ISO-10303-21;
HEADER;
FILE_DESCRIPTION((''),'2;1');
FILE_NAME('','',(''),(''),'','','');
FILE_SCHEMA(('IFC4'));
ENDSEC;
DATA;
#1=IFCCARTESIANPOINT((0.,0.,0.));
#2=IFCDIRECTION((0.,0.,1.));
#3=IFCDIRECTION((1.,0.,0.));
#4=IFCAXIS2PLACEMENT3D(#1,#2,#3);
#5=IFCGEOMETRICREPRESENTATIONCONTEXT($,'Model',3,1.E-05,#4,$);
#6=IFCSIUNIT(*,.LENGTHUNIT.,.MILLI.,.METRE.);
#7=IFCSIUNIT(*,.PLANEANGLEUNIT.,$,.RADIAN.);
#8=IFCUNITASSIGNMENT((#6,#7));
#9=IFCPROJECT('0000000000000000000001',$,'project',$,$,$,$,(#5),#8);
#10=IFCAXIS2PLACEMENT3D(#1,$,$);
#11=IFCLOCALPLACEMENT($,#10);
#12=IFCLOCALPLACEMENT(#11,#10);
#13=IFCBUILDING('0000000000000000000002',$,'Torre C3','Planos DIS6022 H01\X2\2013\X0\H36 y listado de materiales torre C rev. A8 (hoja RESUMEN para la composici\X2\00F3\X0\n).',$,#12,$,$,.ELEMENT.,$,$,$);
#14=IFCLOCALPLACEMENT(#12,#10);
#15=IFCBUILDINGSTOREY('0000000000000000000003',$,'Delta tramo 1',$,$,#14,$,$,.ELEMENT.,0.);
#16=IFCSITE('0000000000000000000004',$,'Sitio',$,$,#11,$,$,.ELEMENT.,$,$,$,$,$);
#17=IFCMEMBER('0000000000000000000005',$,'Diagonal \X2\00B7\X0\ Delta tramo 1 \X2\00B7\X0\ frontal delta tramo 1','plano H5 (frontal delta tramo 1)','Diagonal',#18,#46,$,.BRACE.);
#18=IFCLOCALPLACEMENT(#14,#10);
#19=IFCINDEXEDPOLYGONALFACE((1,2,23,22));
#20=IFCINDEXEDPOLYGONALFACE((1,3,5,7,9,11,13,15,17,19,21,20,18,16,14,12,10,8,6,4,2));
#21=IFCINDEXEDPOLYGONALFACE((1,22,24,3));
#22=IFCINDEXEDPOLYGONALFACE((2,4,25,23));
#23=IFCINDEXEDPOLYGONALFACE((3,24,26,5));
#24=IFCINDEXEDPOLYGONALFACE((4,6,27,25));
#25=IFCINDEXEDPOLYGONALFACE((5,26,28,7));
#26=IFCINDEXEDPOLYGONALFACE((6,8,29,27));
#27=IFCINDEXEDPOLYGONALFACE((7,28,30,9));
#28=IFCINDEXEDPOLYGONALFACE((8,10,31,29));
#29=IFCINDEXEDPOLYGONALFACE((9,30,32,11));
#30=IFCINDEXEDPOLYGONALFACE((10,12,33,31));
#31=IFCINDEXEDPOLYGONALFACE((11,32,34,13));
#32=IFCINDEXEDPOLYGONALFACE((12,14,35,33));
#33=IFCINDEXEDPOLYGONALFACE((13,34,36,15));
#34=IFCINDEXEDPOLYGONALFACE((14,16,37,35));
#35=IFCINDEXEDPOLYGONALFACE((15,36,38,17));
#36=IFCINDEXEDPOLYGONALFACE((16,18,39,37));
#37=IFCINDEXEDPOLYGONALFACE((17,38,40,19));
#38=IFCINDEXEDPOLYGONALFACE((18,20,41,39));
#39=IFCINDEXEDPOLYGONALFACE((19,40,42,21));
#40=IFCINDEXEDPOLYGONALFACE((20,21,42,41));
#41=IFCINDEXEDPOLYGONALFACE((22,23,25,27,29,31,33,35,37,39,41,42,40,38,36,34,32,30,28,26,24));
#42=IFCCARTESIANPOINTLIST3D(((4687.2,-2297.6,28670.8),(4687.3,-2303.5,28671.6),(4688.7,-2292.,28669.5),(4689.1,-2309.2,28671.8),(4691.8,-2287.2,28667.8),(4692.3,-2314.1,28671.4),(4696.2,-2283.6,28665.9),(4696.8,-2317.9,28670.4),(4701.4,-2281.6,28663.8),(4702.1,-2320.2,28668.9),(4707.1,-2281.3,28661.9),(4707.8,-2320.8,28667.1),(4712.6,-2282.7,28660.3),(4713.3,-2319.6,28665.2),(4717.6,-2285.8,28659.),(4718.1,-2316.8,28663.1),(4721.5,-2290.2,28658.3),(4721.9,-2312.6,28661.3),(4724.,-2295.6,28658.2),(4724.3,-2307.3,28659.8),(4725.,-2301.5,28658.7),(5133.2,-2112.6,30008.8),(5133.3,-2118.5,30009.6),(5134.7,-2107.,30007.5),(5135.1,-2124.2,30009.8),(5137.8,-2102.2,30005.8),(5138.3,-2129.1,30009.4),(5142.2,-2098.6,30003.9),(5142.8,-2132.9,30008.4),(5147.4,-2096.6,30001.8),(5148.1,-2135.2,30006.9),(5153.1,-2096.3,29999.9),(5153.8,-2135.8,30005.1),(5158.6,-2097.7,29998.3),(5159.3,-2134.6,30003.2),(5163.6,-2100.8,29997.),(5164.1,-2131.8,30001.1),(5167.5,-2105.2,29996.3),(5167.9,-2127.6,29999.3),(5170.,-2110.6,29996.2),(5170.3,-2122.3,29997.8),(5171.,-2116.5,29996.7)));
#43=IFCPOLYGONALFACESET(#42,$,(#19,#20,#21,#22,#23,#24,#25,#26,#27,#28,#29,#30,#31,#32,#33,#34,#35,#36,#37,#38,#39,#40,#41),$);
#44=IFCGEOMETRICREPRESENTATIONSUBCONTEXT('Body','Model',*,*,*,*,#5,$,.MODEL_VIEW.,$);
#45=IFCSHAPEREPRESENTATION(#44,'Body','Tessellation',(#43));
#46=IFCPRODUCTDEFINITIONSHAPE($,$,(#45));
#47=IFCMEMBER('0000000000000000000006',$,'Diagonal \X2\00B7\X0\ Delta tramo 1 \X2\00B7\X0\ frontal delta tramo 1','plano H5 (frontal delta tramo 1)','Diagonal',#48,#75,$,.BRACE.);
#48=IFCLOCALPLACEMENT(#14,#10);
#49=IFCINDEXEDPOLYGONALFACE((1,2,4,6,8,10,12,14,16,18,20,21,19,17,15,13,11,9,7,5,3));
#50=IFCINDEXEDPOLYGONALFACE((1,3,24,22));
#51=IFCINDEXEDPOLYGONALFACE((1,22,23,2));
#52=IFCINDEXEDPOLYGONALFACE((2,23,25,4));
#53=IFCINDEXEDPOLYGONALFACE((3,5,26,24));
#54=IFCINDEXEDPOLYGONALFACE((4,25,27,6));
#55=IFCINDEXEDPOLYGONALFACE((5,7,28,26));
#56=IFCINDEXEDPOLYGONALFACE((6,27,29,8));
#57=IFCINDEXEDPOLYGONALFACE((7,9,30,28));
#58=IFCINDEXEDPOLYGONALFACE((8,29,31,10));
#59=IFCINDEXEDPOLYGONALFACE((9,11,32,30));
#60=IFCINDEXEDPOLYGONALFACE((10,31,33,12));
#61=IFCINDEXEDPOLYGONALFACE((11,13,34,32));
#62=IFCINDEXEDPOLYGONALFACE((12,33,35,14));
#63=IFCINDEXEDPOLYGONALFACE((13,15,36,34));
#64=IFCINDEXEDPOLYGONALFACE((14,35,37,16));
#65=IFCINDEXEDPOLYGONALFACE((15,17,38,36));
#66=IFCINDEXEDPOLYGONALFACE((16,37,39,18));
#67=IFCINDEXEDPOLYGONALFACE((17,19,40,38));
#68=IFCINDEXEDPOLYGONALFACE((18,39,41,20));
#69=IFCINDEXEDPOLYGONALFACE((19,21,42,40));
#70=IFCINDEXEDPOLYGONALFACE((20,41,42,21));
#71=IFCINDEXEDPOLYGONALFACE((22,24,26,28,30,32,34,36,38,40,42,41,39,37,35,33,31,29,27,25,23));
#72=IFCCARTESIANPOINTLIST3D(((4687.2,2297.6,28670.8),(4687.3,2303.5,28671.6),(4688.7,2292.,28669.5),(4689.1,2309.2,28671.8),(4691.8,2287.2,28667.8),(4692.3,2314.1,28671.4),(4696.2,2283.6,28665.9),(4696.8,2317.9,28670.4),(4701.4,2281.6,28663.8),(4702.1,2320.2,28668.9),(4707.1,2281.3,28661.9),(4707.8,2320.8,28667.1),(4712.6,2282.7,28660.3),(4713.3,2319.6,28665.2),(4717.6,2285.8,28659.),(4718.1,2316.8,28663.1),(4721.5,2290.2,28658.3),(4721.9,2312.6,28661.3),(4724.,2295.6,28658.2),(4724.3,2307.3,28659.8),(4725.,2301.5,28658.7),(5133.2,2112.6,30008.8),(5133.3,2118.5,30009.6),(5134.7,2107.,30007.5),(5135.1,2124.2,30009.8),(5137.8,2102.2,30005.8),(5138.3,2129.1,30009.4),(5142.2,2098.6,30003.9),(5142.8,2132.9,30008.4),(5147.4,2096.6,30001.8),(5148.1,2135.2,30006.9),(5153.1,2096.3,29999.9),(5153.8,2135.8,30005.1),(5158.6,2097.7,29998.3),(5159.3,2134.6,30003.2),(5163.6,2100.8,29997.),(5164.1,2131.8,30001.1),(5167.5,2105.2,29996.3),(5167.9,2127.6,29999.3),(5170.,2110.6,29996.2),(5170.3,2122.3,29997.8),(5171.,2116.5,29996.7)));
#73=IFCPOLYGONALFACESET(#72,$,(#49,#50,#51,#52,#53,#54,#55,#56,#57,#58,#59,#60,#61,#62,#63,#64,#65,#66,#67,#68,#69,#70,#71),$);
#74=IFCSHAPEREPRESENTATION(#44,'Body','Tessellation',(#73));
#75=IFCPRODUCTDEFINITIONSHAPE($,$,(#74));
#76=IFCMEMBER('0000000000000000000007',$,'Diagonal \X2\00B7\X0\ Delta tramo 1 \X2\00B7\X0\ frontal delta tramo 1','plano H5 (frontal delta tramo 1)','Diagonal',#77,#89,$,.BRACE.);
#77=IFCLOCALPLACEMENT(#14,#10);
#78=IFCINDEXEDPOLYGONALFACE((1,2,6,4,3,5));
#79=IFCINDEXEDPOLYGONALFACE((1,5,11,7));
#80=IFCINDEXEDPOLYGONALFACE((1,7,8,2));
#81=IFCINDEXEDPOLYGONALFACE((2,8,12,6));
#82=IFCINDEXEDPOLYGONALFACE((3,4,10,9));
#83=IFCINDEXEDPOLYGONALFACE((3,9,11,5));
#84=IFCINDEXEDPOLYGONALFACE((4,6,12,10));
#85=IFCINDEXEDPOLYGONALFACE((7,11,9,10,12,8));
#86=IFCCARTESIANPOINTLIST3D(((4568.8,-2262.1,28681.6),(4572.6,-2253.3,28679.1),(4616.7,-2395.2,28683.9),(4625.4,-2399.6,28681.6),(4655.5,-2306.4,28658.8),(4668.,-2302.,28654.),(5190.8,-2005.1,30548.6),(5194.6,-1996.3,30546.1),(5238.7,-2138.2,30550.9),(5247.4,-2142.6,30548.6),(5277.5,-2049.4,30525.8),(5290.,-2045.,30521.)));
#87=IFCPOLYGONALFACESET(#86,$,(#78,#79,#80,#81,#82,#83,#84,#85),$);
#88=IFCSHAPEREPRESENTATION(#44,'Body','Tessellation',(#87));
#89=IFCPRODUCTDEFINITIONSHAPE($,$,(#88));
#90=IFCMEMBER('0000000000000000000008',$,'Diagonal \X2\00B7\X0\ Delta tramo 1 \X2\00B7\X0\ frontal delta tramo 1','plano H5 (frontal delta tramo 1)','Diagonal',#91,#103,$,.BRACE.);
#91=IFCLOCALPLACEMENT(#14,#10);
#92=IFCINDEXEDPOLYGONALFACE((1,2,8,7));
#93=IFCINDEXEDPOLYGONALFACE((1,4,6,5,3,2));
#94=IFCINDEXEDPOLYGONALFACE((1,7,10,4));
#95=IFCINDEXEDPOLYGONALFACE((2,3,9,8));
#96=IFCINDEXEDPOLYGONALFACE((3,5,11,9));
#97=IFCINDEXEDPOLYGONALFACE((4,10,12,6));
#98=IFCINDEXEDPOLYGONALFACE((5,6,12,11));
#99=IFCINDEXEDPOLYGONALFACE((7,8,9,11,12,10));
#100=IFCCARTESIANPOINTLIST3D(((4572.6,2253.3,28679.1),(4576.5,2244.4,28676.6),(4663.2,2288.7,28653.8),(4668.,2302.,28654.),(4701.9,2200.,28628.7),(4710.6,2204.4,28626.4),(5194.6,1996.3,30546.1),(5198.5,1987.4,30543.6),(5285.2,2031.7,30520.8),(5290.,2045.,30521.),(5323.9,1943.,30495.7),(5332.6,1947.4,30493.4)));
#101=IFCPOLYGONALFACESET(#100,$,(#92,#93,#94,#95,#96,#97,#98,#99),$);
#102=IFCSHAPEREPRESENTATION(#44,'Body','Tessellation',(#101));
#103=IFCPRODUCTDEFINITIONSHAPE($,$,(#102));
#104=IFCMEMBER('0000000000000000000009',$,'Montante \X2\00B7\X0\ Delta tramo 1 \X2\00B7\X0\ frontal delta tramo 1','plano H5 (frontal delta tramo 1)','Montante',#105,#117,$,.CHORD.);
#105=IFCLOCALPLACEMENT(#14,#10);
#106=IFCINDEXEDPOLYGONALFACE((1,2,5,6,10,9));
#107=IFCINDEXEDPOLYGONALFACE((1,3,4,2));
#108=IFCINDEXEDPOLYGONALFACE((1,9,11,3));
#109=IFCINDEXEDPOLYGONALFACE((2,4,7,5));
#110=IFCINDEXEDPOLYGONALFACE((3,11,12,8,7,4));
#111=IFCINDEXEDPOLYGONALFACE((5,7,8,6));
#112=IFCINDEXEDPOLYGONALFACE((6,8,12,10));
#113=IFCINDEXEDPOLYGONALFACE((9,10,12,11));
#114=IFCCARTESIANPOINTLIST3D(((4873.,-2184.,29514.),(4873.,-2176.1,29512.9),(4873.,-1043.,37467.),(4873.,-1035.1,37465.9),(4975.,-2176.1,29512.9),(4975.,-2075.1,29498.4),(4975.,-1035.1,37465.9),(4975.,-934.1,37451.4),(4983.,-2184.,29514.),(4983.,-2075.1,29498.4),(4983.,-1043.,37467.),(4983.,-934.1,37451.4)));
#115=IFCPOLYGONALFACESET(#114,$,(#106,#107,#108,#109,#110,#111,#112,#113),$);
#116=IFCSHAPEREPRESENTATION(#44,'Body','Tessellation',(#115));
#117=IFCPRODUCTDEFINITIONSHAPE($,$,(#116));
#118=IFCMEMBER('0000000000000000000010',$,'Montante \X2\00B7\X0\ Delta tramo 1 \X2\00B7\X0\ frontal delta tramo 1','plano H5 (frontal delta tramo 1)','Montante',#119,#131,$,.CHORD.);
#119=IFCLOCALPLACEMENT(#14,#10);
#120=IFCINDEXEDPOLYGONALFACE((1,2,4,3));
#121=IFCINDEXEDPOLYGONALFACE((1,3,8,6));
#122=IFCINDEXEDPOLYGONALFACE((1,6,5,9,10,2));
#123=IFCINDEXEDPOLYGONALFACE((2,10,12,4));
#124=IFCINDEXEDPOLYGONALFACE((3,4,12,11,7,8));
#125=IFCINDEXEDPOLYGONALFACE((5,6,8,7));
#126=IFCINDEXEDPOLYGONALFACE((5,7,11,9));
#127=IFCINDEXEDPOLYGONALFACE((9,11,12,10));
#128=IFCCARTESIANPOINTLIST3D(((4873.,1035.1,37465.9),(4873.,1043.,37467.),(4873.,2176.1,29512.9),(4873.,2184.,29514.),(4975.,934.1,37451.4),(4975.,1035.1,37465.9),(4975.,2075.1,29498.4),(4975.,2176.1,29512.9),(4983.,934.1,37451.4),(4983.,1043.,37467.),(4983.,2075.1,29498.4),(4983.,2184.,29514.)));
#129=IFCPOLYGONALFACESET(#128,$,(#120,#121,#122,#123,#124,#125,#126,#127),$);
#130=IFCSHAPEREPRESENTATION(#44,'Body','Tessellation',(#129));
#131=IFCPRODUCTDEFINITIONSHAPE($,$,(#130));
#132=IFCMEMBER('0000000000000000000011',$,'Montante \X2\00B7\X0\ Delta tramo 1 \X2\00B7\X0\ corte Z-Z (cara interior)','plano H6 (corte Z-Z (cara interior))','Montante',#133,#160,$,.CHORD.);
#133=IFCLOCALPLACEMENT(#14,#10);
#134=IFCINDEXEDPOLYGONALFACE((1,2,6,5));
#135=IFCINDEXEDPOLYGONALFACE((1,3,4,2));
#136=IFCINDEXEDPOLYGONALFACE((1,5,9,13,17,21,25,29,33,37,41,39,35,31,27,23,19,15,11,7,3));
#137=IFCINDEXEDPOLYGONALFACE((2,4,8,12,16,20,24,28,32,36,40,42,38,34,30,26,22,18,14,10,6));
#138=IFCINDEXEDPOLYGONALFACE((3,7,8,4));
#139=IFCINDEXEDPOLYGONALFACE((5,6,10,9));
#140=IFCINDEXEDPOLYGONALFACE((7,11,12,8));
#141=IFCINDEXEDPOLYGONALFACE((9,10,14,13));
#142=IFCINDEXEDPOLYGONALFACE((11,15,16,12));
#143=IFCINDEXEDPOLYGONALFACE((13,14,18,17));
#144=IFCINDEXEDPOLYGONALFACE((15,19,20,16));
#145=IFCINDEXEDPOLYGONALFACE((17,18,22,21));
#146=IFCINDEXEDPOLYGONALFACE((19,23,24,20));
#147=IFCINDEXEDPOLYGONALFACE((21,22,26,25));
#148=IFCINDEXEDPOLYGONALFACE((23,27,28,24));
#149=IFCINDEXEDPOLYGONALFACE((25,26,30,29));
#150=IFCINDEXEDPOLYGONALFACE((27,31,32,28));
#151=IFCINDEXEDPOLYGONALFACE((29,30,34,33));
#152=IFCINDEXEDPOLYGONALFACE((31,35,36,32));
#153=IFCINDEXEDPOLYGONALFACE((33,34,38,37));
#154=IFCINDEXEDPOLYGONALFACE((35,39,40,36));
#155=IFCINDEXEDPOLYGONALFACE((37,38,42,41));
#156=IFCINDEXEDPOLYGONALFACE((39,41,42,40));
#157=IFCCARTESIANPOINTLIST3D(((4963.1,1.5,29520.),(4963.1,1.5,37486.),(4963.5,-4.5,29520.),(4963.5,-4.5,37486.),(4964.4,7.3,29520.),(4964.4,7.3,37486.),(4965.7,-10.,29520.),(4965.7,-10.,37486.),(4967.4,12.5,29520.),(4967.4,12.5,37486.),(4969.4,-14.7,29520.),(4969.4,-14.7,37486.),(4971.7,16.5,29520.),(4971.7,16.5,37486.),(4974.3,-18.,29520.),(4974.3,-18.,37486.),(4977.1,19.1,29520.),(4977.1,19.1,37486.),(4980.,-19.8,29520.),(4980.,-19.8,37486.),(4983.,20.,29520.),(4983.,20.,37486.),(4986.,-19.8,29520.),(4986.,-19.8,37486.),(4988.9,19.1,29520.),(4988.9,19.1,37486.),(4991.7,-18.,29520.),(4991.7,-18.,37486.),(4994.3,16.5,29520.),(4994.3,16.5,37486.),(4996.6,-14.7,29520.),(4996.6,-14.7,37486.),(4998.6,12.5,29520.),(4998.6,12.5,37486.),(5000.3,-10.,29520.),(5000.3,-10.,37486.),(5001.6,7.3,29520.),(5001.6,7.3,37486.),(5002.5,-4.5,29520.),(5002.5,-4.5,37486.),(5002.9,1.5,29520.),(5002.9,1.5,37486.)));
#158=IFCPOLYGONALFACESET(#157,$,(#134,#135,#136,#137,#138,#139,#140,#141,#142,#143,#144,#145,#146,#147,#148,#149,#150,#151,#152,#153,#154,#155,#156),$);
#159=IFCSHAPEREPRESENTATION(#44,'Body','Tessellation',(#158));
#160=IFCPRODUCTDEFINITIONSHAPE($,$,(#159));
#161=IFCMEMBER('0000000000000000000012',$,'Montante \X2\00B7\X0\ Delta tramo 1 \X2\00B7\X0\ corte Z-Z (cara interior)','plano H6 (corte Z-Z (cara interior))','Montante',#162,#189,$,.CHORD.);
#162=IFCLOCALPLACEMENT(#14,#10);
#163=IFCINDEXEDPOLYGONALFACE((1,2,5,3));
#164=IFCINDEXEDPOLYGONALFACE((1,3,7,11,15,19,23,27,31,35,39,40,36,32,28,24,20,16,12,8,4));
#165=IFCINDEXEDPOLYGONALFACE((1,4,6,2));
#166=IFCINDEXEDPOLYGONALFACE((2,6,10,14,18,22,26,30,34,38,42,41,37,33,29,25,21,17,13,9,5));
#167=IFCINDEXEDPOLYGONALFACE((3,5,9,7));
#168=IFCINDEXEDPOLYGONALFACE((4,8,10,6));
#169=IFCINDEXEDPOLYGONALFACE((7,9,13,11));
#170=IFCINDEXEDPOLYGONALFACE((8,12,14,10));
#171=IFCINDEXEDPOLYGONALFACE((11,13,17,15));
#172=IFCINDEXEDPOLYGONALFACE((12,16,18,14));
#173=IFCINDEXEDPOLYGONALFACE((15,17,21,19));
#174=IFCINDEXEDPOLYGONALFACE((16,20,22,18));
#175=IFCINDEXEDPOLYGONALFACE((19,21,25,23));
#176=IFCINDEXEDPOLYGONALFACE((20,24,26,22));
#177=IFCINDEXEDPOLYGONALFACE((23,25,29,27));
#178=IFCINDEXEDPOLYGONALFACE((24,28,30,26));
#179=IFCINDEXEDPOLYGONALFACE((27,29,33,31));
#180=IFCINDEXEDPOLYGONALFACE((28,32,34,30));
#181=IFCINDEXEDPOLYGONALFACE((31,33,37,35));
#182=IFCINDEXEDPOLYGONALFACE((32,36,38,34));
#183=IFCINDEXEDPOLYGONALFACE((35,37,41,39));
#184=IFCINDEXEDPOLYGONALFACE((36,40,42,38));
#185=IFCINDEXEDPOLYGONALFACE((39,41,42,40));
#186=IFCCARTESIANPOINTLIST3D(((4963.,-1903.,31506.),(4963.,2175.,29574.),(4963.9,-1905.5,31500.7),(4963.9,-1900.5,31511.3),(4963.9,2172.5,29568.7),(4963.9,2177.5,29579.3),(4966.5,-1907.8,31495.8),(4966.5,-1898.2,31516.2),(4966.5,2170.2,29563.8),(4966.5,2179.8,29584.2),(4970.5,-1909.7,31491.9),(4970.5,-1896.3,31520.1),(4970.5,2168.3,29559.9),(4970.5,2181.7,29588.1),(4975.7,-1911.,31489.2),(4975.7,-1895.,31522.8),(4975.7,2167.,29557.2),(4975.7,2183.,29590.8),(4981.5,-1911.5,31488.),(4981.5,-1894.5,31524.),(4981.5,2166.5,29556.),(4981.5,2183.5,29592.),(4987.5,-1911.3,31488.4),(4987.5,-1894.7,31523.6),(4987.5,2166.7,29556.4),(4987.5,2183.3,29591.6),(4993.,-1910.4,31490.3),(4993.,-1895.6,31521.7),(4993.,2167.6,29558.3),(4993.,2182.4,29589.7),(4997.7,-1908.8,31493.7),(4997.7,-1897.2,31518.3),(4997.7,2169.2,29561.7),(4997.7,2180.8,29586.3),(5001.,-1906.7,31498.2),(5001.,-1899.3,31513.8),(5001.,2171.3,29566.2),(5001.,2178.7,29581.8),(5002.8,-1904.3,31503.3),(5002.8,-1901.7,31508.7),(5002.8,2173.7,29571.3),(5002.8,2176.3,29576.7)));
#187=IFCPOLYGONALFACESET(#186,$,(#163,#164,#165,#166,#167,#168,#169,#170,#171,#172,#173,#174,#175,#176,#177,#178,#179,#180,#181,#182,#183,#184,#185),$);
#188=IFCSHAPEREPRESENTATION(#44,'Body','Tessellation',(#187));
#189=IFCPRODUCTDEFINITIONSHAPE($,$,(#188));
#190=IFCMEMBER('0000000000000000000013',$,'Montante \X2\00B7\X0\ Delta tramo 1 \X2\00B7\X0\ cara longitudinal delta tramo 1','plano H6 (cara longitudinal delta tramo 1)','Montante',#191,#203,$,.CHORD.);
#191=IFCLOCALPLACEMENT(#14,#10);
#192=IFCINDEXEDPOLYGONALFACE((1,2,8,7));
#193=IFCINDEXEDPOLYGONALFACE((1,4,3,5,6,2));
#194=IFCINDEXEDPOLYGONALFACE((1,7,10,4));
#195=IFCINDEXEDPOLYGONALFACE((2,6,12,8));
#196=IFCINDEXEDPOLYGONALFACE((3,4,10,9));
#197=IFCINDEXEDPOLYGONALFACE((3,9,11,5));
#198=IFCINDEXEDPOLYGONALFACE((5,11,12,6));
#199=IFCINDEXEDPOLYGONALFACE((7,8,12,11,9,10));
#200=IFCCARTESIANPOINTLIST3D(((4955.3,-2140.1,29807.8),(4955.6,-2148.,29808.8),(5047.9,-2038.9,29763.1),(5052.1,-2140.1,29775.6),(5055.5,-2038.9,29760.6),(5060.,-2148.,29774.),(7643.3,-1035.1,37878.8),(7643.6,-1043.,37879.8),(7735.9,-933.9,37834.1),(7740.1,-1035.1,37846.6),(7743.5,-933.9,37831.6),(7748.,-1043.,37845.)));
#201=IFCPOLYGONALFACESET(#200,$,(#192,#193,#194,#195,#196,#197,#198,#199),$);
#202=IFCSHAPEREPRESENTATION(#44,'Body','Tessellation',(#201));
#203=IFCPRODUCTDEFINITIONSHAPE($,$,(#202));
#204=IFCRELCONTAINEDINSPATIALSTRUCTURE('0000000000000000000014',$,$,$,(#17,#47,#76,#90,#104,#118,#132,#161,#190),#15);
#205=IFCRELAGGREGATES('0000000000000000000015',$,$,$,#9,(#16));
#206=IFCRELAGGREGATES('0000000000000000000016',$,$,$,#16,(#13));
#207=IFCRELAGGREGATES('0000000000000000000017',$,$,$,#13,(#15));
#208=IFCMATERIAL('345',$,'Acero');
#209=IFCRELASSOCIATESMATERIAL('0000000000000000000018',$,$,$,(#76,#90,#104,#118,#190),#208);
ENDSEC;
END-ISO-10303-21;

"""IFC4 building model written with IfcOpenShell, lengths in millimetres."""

from ifc_helpers import new_model, si_unit, frame, frame_2d, origin, origin_with_axes, place, context, subcontext, project, spatial, circle, l_section, extrude, material, element, save


model = new_model("IFC4")

# Units and contexts
model_context = context("Model", 3, precision=1e-05, world=origin_with_axes())
body_context = subcontext(model_context, "Body", "Model", "MODEL_VIEW")
ifc_project = project(units=[si_unit("LENGTHUNIT", "METRE", prefix="MILLI"), si_unit("PLANEANGLEUNIT", "RADIAN")], contexts=[model_context])

# Site, building, storey
site_placement = place(None, origin())
site = spatial("IfcSite", under=ifc_project, at=site_placement, Name="Sitio", CompositionType="ELEMENT")
building_placement = place(site_placement, origin())
building = spatial("IfcBuilding", under=site, at=building_placement, Name="Torre C3", Description="Planos DIS6022 H01–H36 y listado de materiales torre C rev. A8 (hoja RESUMEN para la composición).", CompositionType="ELEMENT")
storey_placement = place(building_placement, origin())
storey = spatial("IfcBuildingStorey", under=building, at=storey_placement, Name="Delta tramo 1", CompositionType="ELEMENT", Elevation=0.0)

# Members
for number, where, z_axis, x_axis, name in (
    (1, (4706.0, -2301.0, 28665.0), (0.313542, 0.130057, 0.940626), (-0.863292, 0.451616, 0.225321), "Diagonal · Delta tramo 1 · frontal delta tramo 1"),
    (2, (4706.0, 2301.0, 28665.0), (0.313542, -0.130057, 0.940626), (-0.863292, -0.451616, 0.225321), "Diagonal · Delta tramo 1 · frontal delta tramo 1"),
):
    element("IfcMember", number, at=place(storey_placement, frame(where, z_axis=z_axis, x_axis=x_axis)), inside=storey, Name=name, Description="plano H5 (frontal delta tramo 1)", ObjectType="Diagonal", PredefinedType="BRACE", context=body_context, shape_type="SweptSolid", body=[
        extrude(circle(Radius=20.0), None, (0.0, 0.0, 1.0), 1422.5),
    ])
ifc_material_1 = material(Name="345", Category="Acero")
for number, where, z_axis, x_axis, name in (
    (3, (4668.0, -2302.0, 28654.0), (0.313414, 0.129497, 0.940746), (-0.867067, 0.443015, 0.227885), "Diagonal · Delta tramo 1 · frontal delta tramo 1"),
    (4, (4668.0, 2302.0, 28654.0), (0.313414, -0.129497, 0.940746), (-0.867067, -0.443015, 0.227885), "Diagonal · Delta tramo 1 · frontal delta tramo 1"),
):
    element("IfcMember", number, at=place(storey_placement, frame(where, z_axis=z_axis, x_axis=x_axis)), inside=storey, material=ifc_material_1, Name=name, Description="plano H5 (frontal delta tramo 1)", ObjectType="Diagonal", PredefinedType="BRACE", context=body_context, shape_type="SweptSolid", body=[
        extrude(l_section(Depth=110.0, Width=110.0, Thickness=10.0, at=frame_2d((55.0, 55.0))), None, (0.0, 0.0, 1.0), 1984.6),
    ])
for number, where, z_axis, x_axis, name in (
    (5, (4983.0, -2184.0, 29514.0), (0.0, 0.142014, 0.989865), (0.0, 0.989865, -0.142014), "Montante · Delta tramo 1 · frontal delta tramo 1"),
    (6, (4983.0, 2184.0, 29514.0), (0.0, -0.142014, 0.989865), (-1.0, 0.0, 0.0), "Montante · Delta tramo 1 · frontal delta tramo 1"),
):
    element("IfcMember", number, at=place(storey_placement, frame(where, z_axis=z_axis, x_axis=x_axis)), inside=storey, material=ifc_material_1, Name=name, Description="plano H5 (frontal delta tramo 1)", ObjectType="Montante", PredefinedType="CHORD", context=body_context, shape_type="SweptSolid", body=[
        extrude(l_section(Depth=110.0, Width=110.0, Thickness=8.0, at=frame_2d((55.0, 55.0))), None, (0.0, 0.0, 1.0), 8034.4),
    ])
member_1_placement = place(storey_placement, frame((4983.0, 0.0, 29520.0), z_axis=(0.0, 0.0, 1.0), x_axis=(0.0, 1.0, 0.0)))
element("IfcMember", 7, at=member_1_placement, inside=storey, Name="Montante · Delta tramo 1 · corte Z-Z (cara interior)", Description="plano H6 (corte Z-Z (cara interior))", ObjectType="Montante", PredefinedType="CHORD", context=body_context, shape_type="SweptSolid", body=[
    extrude(circle(Radius=20.0), None, (0.0, 0.0, 1.0), 7966.0),
])
member_2_placement = place(storey_placement, frame((4983.0, 2175.0, 29574.0), z_axis=(0.0, -0.903711, 0.428144), x_axis=(-1.0, 0.0, 0.0)))
element("IfcMember", 8, at=member_2_placement, inside=storey, Name="Montante · Delta tramo 1 · corte Z-Z (cara interior)", Description="plano H6 (corte Z-Z (cara interior))", ObjectType="Montante", PredefinedType="CHORD", context=body_context, shape_type="SweptSolid", body=[
    extrude(circle(Radius=20.0), None, (0.0, 0.0, 1.0), 4512.5),
])
member_3_placement = place(storey_placement, frame((5060.0, -2148.0, 29774.0), z_axis=(0.313348, 0.128813, 0.940861), x_axis=(-0.040703, 0.991669, -0.122214)))
element("IfcMember", 9, at=member_3_placement, inside=storey, material=ifc_material_1, Name="Montante · Delta tramo 1 · cara longitudinal delta tramo 1", Description="plano H6 (cara longitudinal delta tramo 1)", ObjectType="Montante", PredefinedType="CHORD", context=body_context, shape_type="SweptSolid", body=[
    extrude(l_section(Depth=110.0, Width=110.0, Thickness=8.0, at=frame_2d((55.0, 55.0))), None, (0.0, 0.0, 1.0), 8578.3),
])

save(model, "model.ifc")
